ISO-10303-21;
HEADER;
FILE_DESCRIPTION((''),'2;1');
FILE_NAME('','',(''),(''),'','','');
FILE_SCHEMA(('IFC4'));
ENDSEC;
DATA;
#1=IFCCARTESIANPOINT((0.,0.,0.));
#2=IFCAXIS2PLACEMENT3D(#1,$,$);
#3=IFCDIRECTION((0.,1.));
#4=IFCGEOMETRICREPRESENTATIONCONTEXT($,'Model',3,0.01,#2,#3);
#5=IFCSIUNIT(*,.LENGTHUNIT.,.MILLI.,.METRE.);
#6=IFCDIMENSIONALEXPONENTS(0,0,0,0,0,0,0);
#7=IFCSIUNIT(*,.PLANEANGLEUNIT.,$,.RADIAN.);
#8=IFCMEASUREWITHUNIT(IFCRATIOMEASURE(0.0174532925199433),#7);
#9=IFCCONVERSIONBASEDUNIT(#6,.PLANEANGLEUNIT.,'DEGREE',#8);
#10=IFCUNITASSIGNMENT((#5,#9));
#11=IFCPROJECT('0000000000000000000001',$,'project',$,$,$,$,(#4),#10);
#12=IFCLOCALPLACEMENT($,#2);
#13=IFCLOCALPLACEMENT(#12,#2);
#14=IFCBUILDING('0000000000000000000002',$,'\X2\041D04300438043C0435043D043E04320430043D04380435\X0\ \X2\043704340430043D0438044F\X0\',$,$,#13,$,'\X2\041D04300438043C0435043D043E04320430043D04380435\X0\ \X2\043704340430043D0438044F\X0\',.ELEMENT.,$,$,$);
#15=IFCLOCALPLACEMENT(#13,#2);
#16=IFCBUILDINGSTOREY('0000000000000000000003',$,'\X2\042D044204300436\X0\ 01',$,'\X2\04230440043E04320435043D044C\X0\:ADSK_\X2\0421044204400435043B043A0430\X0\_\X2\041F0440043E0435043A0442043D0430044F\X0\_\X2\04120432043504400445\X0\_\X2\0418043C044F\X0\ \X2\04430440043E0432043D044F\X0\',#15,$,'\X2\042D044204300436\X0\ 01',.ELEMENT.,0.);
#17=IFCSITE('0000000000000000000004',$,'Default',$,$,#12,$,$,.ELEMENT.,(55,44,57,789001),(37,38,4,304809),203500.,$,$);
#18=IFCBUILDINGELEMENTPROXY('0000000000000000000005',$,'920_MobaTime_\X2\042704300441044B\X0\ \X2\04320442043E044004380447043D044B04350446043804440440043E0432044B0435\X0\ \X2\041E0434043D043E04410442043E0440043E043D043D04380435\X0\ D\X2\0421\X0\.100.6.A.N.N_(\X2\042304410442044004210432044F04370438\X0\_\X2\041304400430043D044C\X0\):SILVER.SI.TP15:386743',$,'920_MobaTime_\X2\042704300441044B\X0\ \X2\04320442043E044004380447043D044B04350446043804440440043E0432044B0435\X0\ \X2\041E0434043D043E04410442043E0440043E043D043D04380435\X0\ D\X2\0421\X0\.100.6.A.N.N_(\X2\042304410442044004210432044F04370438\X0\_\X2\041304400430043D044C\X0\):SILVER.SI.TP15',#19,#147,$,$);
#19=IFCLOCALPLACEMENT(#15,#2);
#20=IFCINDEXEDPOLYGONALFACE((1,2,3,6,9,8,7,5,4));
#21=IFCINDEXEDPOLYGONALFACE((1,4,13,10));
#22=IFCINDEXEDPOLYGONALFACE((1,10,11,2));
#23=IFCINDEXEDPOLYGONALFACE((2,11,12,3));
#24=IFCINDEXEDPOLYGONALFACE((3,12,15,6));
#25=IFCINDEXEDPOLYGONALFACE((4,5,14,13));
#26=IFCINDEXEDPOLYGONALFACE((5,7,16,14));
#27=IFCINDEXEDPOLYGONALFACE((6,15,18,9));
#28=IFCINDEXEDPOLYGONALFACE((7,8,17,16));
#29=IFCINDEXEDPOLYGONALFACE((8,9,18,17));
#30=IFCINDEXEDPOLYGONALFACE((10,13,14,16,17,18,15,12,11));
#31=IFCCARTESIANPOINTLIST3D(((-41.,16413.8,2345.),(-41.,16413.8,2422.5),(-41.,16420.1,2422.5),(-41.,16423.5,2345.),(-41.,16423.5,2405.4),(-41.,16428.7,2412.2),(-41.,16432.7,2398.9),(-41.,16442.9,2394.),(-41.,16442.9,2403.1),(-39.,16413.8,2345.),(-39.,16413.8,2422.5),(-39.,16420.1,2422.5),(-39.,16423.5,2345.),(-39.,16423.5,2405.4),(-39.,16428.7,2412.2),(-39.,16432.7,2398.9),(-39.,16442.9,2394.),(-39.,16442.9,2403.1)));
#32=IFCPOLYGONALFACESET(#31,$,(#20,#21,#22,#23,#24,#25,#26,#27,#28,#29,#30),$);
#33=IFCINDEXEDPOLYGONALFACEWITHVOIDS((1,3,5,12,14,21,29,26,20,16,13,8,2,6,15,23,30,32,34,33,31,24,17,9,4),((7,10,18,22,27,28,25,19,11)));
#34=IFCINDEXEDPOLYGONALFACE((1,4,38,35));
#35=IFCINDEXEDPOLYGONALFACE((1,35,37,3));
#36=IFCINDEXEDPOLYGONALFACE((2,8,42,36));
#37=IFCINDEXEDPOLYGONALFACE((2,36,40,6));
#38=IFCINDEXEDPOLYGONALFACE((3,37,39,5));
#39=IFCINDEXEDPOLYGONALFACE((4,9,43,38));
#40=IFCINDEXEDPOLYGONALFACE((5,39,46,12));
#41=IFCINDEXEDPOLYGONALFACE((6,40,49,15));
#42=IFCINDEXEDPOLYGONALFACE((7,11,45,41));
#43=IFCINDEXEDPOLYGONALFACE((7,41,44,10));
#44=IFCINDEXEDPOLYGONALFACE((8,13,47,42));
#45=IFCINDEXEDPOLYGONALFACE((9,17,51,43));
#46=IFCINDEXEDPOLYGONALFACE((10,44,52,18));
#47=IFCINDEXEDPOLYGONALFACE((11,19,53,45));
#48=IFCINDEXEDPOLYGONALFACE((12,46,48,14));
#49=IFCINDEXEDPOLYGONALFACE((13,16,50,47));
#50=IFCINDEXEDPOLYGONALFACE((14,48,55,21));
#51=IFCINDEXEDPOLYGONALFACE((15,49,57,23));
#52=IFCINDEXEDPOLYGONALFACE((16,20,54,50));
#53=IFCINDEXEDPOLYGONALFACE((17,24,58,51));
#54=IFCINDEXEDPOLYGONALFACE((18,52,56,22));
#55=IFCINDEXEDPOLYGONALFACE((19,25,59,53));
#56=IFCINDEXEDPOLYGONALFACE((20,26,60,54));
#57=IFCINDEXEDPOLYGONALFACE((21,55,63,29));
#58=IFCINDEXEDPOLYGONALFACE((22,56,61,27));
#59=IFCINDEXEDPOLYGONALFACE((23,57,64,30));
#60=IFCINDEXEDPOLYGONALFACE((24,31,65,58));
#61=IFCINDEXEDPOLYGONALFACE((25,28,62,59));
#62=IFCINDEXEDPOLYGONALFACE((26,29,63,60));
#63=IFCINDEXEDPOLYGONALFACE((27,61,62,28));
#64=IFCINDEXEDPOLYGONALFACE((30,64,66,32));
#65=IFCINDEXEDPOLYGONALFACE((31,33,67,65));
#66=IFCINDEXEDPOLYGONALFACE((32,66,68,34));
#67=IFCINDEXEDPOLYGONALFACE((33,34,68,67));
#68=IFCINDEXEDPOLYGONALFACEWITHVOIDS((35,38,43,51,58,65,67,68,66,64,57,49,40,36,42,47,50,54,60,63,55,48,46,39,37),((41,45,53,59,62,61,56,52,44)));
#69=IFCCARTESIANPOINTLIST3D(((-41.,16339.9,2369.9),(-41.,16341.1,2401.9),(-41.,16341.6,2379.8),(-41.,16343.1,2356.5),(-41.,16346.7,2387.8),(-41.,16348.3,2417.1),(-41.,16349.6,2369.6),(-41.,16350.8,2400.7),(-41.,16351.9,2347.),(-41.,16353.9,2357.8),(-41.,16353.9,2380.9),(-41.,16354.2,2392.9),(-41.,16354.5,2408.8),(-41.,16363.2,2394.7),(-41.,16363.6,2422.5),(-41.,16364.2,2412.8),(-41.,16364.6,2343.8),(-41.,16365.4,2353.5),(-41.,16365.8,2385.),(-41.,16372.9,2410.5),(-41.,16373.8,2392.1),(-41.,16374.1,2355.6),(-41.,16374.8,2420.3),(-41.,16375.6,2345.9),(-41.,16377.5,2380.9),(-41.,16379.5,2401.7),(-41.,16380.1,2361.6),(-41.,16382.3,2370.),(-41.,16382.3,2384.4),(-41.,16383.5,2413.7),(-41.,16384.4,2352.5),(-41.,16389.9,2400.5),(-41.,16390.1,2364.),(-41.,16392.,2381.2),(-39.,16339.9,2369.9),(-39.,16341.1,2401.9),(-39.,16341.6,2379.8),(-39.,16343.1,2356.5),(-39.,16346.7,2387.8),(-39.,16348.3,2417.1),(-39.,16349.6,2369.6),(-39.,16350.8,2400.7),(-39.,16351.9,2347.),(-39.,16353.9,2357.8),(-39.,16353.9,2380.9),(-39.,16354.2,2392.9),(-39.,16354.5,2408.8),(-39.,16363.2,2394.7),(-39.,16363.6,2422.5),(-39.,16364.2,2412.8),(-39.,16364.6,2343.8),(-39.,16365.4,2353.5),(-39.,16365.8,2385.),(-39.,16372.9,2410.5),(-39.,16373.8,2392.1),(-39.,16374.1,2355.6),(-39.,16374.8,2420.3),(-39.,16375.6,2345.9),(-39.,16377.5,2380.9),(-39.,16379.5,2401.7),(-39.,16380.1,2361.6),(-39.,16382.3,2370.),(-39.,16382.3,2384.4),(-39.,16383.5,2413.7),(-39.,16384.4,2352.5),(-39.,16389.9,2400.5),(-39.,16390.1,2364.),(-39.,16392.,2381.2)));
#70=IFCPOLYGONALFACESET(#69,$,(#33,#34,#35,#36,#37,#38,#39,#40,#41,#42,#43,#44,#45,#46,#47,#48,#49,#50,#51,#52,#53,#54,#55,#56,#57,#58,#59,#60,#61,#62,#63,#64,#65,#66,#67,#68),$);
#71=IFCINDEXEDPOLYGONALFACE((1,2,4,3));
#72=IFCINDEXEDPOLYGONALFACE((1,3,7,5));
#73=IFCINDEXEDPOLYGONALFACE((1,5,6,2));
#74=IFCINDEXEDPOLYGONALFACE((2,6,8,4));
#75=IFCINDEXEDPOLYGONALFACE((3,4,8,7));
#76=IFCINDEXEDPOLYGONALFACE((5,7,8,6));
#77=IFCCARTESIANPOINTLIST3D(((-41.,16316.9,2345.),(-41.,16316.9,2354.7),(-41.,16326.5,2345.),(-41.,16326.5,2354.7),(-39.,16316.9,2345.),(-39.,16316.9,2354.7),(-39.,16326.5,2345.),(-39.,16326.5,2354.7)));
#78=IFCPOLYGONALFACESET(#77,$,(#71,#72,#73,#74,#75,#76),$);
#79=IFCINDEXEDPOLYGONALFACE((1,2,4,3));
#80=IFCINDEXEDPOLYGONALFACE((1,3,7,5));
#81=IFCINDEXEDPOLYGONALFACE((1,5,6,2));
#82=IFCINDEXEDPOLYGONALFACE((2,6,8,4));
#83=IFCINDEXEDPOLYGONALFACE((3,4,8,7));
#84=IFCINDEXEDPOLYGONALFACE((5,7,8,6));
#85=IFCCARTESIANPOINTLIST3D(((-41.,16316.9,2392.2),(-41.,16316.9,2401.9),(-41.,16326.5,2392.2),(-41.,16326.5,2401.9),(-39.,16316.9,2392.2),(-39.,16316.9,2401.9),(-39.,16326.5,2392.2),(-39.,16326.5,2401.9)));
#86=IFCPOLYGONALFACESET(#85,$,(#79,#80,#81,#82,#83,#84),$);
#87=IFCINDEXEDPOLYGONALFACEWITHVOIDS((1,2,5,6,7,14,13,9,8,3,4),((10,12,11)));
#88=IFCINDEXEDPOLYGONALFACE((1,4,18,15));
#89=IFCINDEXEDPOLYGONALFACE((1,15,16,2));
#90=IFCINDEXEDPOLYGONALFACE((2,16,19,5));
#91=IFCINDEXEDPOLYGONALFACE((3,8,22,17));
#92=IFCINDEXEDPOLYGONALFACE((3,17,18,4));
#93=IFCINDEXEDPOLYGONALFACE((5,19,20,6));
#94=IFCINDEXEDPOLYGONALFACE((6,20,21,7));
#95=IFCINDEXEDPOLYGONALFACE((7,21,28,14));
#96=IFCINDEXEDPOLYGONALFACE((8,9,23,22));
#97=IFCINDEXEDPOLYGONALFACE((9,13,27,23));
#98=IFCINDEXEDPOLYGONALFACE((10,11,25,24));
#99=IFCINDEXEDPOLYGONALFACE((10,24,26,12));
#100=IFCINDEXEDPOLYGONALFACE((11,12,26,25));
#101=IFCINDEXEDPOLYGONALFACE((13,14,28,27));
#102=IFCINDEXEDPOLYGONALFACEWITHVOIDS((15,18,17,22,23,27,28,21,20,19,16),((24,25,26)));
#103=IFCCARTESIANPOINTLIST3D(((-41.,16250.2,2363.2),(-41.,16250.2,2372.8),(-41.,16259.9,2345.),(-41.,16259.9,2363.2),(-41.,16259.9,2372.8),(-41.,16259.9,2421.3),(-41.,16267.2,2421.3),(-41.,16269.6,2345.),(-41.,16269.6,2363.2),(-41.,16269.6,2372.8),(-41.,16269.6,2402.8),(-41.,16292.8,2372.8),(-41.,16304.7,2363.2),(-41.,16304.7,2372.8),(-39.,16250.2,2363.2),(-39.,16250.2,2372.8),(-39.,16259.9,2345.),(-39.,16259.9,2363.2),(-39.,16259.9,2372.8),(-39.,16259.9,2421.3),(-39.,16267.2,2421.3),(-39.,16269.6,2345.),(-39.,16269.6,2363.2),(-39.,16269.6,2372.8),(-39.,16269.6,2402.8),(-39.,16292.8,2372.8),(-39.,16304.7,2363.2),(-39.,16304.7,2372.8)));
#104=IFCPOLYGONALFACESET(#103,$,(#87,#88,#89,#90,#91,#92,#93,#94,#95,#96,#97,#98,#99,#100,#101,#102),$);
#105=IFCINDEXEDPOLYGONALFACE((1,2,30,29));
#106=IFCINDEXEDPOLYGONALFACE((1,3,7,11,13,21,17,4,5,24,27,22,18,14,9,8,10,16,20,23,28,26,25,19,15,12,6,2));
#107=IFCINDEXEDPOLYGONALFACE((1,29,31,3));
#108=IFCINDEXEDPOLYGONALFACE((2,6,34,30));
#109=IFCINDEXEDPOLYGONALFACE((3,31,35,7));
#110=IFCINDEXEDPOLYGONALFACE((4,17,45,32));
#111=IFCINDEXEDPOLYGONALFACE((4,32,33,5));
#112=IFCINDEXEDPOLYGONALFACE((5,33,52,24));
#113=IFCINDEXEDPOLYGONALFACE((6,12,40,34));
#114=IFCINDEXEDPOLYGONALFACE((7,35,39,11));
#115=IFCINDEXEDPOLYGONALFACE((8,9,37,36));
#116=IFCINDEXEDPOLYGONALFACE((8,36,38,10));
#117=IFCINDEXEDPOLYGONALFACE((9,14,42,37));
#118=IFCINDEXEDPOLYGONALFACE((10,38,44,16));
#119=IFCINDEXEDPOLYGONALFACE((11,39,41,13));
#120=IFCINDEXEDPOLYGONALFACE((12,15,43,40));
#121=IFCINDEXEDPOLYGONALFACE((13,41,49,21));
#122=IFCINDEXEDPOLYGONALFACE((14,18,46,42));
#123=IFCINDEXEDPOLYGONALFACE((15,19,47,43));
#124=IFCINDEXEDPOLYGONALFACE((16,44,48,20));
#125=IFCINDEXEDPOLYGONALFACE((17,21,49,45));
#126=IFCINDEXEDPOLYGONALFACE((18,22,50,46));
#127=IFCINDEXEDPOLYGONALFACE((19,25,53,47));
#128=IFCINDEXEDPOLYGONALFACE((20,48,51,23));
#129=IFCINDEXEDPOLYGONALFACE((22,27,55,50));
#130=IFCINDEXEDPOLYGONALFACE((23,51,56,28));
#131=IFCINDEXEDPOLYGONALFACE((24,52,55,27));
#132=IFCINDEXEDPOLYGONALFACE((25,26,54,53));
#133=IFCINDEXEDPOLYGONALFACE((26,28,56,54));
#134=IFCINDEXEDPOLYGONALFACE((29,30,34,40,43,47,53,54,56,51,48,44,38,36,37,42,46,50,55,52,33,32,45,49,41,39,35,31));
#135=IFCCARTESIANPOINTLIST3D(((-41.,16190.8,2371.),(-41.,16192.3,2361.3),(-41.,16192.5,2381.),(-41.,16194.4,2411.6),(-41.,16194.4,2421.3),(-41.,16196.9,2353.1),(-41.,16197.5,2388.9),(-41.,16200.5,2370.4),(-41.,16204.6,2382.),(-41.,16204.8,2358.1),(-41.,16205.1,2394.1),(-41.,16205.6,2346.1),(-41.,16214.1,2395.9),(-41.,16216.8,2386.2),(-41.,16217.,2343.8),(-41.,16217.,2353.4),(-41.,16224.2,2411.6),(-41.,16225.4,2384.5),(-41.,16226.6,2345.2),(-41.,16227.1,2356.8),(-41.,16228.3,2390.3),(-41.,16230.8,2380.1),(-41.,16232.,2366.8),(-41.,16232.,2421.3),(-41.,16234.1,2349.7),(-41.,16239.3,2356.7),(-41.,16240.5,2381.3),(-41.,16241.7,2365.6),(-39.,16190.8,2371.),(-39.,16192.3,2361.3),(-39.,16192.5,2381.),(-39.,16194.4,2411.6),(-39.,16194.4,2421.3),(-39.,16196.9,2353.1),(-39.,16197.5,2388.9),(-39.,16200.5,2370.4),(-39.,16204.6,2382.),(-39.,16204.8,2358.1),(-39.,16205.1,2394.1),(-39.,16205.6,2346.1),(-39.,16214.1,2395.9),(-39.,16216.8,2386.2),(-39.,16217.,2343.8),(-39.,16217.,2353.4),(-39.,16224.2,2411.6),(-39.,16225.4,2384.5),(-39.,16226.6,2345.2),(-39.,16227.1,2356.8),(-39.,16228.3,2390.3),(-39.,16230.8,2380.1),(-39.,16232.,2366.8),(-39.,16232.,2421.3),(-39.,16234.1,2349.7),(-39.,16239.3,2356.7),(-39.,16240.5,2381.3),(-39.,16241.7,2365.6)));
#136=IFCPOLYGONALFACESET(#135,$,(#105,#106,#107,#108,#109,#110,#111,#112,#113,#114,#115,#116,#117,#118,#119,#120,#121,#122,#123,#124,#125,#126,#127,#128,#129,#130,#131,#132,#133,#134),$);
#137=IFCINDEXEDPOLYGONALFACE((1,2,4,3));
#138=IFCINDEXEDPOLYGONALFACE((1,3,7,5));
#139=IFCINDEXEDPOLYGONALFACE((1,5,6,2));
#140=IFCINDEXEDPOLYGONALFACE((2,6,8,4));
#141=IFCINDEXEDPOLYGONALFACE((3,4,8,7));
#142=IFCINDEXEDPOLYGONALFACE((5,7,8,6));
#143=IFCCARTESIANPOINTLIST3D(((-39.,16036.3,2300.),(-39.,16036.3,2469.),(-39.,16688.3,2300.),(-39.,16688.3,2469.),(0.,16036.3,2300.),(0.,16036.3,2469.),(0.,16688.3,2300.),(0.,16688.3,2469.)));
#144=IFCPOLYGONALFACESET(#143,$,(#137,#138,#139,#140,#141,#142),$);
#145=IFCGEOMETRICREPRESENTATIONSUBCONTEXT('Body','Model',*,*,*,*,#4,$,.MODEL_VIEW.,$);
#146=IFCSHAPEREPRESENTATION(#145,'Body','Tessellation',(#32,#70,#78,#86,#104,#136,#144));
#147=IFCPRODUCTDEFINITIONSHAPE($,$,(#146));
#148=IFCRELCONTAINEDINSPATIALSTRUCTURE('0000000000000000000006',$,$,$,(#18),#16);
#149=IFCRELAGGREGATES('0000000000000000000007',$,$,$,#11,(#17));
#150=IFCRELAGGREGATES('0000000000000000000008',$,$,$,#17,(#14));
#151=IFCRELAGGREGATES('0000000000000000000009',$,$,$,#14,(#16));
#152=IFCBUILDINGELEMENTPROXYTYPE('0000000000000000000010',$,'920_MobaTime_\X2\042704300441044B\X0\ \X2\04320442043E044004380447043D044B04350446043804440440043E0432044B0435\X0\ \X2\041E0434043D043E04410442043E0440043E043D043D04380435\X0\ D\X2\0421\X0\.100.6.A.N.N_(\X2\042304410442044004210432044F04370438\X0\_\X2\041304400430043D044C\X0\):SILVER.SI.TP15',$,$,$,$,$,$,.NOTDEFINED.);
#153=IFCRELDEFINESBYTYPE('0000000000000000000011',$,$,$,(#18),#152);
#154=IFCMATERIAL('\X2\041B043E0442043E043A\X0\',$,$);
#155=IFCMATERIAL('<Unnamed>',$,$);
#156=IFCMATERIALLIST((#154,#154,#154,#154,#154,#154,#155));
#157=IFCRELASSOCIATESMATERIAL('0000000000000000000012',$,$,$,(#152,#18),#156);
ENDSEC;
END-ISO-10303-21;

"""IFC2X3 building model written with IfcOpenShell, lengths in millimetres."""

from ifc_helpers import new_model, entity, si_unit, converted_unit, direction, frame, origin, origin_2d_with_axis, place, context, subcontext, project, spatial, polyline, rectangle, outline, extrude, source, transform, mapped, material, material_list, type_object, type_shapes, element, save


model = new_model("IFC2X3")

# Units and contexts
model_context = context("Model", 3, precision=0.01, world=origin(), true_north=direction((0.0, 1.0)))
body_context = subcontext(model_context, "Body", "Model", "MODEL_VIEW")
ifc_project = project(units=[si_unit("LENGTHUNIT", "METRE", prefix="MILLI"), converted_unit("PLANEANGLEUNIT", "DEGREE", entity("IfcRatioMeasure", 0.0174532925199433), si_unit("PLANEANGLEUNIT", "RADIAN"), dimensions=[0, 0, 0, 0, 0, 0, 0])], contexts=[model_context])

# Site, building, storey
site_placement = place(None, origin())
site = spatial("IfcSite", under=ifc_project, at=site_placement, Name="Default", CompositionType="ELEMENT", RefLatitude=(55, 44, 57, 789001), RefLongitude=(37, 38, 4, 304809), RefElevation=203500.0)
building_placement = place(site_placement, origin())
building = spatial("IfcBuilding", under=site, at=building_placement, Name="Наименование здания", LongName="Наименование здания", CompositionType="ELEMENT")
storey_placement = place(building_placement, origin())
storey = spatial("IfcBuildingStorey", under=building, at=storey_placement, Name="Этаж 01", ObjectType="Уровень:ADSK_Стрелка_Проектная_Вверх_Имя уровня", LongName="Этаж 01", CompositionType="ELEMENT", Elevation=0.0)

# Building element proxy
ifc_material_1 = material(Name="Лоток")
ifc_material_2 = material(Name="<Unnamed>")
ifc_material_list_1 = material_list([ifc_material_1, ifc_material_1, ifc_material_1, ifc_material_1, ifc_material_1, ifc_material_1, ifc_material_2])
building_element_proxy_type = type_object("IfcBuildingElementProxyType", Name="920_MobaTime_Часы вторичныецифровые Односторонние DС.100.6.A.N.N_(УстрСвязи_Грань):SILVER.SI.TP15", PredefinedType="NOTDEFINED", material=ifc_material_list_1)
shared_shape = source(origin(), body_context, "Body", "SweptSolid", [
    extrude(outline(polyline([(-49.3, -13.1), (28.2, -13.1), (28.2, -6.8), (17.9, 1.8), (8.8, 16.0), (-0.3, 16.0), (4.6, 5.8), (11.1, -3.4), (-49.3, -3.4), (-49.3, -13.1)])), frame((-64.6, 9.8, 39.0), z_axis=(0.0, 0.0, 1.0), x_axis=(0.0, 1.0, 0.0)), (0.0, 0.0, 1.0), 2.0),
    extrude(outline(polyline([(2.2, -27.6), (19.0, -27.6), (30.5, -16.1), (33.3, -4.9), (31.0, 5.8), (21.8, 17.2), (5.2, 27.3), (-11.1, 33.0), (-24.0, 32.7), (-33.6, 27.6), (-40.3, 18.6), (-42.8, 5.7), (-38.0, -6.3), (-27.2, -14.9), (-17.5, -17.7), (-8.2, -16.4), (-0.3, -11.9), (5.1, -4.5), (7.3, 6.2), (4.0, 17.2), (18.4, 7.3), (23.6, -2.4), (22.0, -11.4), (14.2, -18.4), (5.3, -18.3), (2.2, -27.6)]), holes=[polyline([(-9.0, 23.3), (-1.3, 14.3), (-2.5, 2.0), (-11.4, -7.0), (-23.4, -6.0), (-32.2, 2.9), (-31.2, 15.1), (-25.6, 22.1), (-17.5, 24.9), (-9.0, 23.3)])]), frame((-2.7, 3.6, 39.0), z_axis=(0.0, 0.0, 1.0), x_axis=(-0.427649, 0.903945, 0.0)), (0.0, 0.0, 1.0), 2.0),
    extrude(rectangle(XDim=9.7, YDim=9.7, at=origin_2d_with_axis()), frame((40.6, -34.7, 39.0)), (0.0, 0.0, 1.0), 2.0),
    extrude(rectangle(XDim=9.7, YDim=9.7, at=origin_2d_with_axis()), frame((40.6, 12.6, 39.0)), (0.0, 0.0, 1.0), 2.0),
    extrude(outline(polyline([(-0.9, -28.1), (8.8, -28.1), (8.8, -9.9), (18.5, -9.9), (18.5, -0.2), (8.8, -0.2), (8.8, 48.3), (1.5, 48.3), (-36.0, -0.2), (-36.0, -9.9), (-0.9, -9.9), (-0.9, -28.1)]), holes=[polyline([(-0.9, -0.2), (-24.1, -0.2), (-0.9, 29.7), (-0.9, -0.2)])]), frame((93.6, -11.4, 39.0)), (0.0, 0.0, 1.0), 2.0),
    extrude(outline(polyline([(3.3, -28.3), (12.5, -28.3), (20.5, -25.0), (26.8, -18.9), (30.7, -10.0), (31.4, 1.6), (26.9, 11.8), (20.1, 18.4), (11.1, 22.3), (1.0, 23.3), (-7.9, 20.4), (-14.9, 14.5), (-18.9, 6.2), (-17.1, -9.0), (-36.7, 0.5), (-29.1, 29.2), (-38.5, 31.7), (-48.1, -4.6), (-11.6, -23.1), (-8.0, -14.0), (-10.8, -7.6), (-10.2, 1.1), (-3.0, 11.8), (9.2, 12.8), (20.0, 5.5), (21.4, -7.5), (15.5, -16.4), (4.6, -18.6), (3.3, -28.3)])), frame((147.1, -8.5, 39.0), z_axis=(0.0, 0.0, 1.0), x_axis=(0.256974, -0.966418, 0.0)), (0.0, 0.0, 1.0), 2.0),
    extrude(rectangle(XDim=652.0, YDim=169.0, at=origin_2d_with_axis()), frame((0.0, 0.0, 0.0), z_axis=(0.0, 0.0, 1.0), x_axis=(-1.0, 0.0, 0.0)), (0.0, 0.0, 1.0), 39.0),
])
type_shapes(building_element_proxy_type, [shared_shape])
proxy_placement = place(storey_placement, frame((0.0, 16362.3, 2384.5), z_axis=(-1.0, 0.0, 0.0), x_axis=(0.0, -1.0, 0.0)))
element("IfcBuildingElementProxy", 1, at=proxy_placement, inside=storey, type_object=building_element_proxy_type, material=ifc_material_list_1, Name="920_MobaTime_Часы вторичныецифровые Односторонние DС.100.6.A.N.N_(УстрСвязи_Грань):SILVER.SI.TP15:386743", ObjectType="920_MobaTime_Часы вторичныецифровые Односторонние DС.100.6.A.N.N_(УстрСвязи_Грань):SILVER.SI.TP15", context=body_context, shape_type="MappedRepresentation", body=[
    mapped(shared_shape, transform((0.0, 0.0, 0.0), scale=1.0)),
])

save(model, "model.ifc")
